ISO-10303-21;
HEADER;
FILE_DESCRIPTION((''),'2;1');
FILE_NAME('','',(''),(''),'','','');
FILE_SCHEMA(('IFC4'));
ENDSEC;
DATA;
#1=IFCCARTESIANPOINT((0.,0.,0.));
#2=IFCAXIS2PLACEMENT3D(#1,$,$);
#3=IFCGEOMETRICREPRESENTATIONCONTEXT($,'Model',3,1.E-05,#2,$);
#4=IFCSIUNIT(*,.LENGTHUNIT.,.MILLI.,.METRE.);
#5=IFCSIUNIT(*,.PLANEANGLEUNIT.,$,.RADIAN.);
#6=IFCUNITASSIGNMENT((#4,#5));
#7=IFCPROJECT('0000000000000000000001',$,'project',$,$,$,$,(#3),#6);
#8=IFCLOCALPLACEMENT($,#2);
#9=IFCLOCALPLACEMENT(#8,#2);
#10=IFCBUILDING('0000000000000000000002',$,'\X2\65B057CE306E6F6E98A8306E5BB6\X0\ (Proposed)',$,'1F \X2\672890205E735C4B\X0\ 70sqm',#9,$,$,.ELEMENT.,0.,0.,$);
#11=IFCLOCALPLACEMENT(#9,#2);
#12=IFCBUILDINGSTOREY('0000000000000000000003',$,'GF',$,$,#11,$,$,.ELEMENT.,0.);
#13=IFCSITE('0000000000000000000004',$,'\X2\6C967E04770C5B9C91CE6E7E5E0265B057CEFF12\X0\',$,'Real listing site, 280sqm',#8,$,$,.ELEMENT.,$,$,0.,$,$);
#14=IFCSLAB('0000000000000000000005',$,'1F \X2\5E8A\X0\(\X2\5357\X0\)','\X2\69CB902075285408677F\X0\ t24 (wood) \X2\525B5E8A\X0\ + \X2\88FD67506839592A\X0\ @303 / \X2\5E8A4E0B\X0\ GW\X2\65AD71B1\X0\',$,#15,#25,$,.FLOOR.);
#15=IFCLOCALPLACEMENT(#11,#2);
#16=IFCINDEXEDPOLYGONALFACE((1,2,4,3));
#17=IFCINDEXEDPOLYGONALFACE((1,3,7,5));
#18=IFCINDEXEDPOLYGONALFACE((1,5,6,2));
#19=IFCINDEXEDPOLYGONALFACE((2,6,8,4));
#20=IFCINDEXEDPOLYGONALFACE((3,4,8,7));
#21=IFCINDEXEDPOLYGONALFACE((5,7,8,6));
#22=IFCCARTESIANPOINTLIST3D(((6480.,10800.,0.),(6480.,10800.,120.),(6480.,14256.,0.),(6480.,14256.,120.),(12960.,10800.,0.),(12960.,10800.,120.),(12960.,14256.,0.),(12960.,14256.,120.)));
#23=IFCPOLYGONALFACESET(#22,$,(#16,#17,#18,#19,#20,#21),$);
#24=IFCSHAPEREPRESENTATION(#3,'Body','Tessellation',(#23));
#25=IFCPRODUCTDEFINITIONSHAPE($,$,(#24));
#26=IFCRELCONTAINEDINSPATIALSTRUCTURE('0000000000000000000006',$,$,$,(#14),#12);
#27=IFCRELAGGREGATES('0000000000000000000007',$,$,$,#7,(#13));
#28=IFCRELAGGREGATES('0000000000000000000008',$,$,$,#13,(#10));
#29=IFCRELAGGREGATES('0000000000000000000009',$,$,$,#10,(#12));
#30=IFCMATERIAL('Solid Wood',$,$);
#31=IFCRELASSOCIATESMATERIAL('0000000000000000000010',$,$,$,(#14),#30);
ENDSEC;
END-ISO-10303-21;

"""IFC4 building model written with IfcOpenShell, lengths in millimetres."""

from ifc_helpers import new_model, si_unit, frame, frame_2d, origin, place, context, project, spatial, rectangle, extrude, material, element, save


model = new_model("IFC4")

# Units and contexts
model_context = context("Model", 3, precision=1e-05, world=origin())
ifc_project = project(units=[si_unit("LENGTHUNIT", "METRE", prefix="MILLI"), si_unit("PLANEANGLEUNIT", "RADIAN")], contexts=[model_context])

# Site, building, storey
site_placement = place(None, origin())
site = spatial("IfcSite", under=ifc_project, at=site_placement, Name="沖縄県宜野湾市新城２", ObjectType="Real listing site, 280sqm", CompositionType="ELEMENT", RefElevation=0.0)
building_placement = place(site_placement, origin())
building = spatial("IfcBuilding", under=site, at=building_placement, Name="新城の潮風の家 (Proposed)", ObjectType="1F 木造平屋 70sqm", CompositionType="ELEMENT", ElevationOfRefHeight=0.0, ElevationOfTerrain=0.0)
storey_placement = place(building_placement, origin())
storey = spatial("IfcBuildingStorey", under=building, at=storey_placement, Name="GF", CompositionType="ELEMENT", Elevation=0.0)

# Shared definitions
ifc_material_1 = material(Name="Solid Wood")

# Slab
slab_1_placement = place(storey_placement, frame((3240.0, 5400.0, 0.0)))
element("IfcSlab", 1, at=slab_1_placement, inside=storey, material=ifc_material_1, Name="1F 床(南)", Description="構造用合板 t24 (wood) 剛床 + 製材根太 @303 / 床下 GW断熱", PredefinedType="FLOOR", context=model_context, shape_type="SweptSolid", body=[
    extrude(rectangle(XDim=6480.0, YDim=3456.0, at=frame_2d((3240.0, 1728.0))), frame((3240.0, 5400.0, 0.0)), (0.0, 0.0, 1.0), 120.0),
])

save(model, "model.ifc")
